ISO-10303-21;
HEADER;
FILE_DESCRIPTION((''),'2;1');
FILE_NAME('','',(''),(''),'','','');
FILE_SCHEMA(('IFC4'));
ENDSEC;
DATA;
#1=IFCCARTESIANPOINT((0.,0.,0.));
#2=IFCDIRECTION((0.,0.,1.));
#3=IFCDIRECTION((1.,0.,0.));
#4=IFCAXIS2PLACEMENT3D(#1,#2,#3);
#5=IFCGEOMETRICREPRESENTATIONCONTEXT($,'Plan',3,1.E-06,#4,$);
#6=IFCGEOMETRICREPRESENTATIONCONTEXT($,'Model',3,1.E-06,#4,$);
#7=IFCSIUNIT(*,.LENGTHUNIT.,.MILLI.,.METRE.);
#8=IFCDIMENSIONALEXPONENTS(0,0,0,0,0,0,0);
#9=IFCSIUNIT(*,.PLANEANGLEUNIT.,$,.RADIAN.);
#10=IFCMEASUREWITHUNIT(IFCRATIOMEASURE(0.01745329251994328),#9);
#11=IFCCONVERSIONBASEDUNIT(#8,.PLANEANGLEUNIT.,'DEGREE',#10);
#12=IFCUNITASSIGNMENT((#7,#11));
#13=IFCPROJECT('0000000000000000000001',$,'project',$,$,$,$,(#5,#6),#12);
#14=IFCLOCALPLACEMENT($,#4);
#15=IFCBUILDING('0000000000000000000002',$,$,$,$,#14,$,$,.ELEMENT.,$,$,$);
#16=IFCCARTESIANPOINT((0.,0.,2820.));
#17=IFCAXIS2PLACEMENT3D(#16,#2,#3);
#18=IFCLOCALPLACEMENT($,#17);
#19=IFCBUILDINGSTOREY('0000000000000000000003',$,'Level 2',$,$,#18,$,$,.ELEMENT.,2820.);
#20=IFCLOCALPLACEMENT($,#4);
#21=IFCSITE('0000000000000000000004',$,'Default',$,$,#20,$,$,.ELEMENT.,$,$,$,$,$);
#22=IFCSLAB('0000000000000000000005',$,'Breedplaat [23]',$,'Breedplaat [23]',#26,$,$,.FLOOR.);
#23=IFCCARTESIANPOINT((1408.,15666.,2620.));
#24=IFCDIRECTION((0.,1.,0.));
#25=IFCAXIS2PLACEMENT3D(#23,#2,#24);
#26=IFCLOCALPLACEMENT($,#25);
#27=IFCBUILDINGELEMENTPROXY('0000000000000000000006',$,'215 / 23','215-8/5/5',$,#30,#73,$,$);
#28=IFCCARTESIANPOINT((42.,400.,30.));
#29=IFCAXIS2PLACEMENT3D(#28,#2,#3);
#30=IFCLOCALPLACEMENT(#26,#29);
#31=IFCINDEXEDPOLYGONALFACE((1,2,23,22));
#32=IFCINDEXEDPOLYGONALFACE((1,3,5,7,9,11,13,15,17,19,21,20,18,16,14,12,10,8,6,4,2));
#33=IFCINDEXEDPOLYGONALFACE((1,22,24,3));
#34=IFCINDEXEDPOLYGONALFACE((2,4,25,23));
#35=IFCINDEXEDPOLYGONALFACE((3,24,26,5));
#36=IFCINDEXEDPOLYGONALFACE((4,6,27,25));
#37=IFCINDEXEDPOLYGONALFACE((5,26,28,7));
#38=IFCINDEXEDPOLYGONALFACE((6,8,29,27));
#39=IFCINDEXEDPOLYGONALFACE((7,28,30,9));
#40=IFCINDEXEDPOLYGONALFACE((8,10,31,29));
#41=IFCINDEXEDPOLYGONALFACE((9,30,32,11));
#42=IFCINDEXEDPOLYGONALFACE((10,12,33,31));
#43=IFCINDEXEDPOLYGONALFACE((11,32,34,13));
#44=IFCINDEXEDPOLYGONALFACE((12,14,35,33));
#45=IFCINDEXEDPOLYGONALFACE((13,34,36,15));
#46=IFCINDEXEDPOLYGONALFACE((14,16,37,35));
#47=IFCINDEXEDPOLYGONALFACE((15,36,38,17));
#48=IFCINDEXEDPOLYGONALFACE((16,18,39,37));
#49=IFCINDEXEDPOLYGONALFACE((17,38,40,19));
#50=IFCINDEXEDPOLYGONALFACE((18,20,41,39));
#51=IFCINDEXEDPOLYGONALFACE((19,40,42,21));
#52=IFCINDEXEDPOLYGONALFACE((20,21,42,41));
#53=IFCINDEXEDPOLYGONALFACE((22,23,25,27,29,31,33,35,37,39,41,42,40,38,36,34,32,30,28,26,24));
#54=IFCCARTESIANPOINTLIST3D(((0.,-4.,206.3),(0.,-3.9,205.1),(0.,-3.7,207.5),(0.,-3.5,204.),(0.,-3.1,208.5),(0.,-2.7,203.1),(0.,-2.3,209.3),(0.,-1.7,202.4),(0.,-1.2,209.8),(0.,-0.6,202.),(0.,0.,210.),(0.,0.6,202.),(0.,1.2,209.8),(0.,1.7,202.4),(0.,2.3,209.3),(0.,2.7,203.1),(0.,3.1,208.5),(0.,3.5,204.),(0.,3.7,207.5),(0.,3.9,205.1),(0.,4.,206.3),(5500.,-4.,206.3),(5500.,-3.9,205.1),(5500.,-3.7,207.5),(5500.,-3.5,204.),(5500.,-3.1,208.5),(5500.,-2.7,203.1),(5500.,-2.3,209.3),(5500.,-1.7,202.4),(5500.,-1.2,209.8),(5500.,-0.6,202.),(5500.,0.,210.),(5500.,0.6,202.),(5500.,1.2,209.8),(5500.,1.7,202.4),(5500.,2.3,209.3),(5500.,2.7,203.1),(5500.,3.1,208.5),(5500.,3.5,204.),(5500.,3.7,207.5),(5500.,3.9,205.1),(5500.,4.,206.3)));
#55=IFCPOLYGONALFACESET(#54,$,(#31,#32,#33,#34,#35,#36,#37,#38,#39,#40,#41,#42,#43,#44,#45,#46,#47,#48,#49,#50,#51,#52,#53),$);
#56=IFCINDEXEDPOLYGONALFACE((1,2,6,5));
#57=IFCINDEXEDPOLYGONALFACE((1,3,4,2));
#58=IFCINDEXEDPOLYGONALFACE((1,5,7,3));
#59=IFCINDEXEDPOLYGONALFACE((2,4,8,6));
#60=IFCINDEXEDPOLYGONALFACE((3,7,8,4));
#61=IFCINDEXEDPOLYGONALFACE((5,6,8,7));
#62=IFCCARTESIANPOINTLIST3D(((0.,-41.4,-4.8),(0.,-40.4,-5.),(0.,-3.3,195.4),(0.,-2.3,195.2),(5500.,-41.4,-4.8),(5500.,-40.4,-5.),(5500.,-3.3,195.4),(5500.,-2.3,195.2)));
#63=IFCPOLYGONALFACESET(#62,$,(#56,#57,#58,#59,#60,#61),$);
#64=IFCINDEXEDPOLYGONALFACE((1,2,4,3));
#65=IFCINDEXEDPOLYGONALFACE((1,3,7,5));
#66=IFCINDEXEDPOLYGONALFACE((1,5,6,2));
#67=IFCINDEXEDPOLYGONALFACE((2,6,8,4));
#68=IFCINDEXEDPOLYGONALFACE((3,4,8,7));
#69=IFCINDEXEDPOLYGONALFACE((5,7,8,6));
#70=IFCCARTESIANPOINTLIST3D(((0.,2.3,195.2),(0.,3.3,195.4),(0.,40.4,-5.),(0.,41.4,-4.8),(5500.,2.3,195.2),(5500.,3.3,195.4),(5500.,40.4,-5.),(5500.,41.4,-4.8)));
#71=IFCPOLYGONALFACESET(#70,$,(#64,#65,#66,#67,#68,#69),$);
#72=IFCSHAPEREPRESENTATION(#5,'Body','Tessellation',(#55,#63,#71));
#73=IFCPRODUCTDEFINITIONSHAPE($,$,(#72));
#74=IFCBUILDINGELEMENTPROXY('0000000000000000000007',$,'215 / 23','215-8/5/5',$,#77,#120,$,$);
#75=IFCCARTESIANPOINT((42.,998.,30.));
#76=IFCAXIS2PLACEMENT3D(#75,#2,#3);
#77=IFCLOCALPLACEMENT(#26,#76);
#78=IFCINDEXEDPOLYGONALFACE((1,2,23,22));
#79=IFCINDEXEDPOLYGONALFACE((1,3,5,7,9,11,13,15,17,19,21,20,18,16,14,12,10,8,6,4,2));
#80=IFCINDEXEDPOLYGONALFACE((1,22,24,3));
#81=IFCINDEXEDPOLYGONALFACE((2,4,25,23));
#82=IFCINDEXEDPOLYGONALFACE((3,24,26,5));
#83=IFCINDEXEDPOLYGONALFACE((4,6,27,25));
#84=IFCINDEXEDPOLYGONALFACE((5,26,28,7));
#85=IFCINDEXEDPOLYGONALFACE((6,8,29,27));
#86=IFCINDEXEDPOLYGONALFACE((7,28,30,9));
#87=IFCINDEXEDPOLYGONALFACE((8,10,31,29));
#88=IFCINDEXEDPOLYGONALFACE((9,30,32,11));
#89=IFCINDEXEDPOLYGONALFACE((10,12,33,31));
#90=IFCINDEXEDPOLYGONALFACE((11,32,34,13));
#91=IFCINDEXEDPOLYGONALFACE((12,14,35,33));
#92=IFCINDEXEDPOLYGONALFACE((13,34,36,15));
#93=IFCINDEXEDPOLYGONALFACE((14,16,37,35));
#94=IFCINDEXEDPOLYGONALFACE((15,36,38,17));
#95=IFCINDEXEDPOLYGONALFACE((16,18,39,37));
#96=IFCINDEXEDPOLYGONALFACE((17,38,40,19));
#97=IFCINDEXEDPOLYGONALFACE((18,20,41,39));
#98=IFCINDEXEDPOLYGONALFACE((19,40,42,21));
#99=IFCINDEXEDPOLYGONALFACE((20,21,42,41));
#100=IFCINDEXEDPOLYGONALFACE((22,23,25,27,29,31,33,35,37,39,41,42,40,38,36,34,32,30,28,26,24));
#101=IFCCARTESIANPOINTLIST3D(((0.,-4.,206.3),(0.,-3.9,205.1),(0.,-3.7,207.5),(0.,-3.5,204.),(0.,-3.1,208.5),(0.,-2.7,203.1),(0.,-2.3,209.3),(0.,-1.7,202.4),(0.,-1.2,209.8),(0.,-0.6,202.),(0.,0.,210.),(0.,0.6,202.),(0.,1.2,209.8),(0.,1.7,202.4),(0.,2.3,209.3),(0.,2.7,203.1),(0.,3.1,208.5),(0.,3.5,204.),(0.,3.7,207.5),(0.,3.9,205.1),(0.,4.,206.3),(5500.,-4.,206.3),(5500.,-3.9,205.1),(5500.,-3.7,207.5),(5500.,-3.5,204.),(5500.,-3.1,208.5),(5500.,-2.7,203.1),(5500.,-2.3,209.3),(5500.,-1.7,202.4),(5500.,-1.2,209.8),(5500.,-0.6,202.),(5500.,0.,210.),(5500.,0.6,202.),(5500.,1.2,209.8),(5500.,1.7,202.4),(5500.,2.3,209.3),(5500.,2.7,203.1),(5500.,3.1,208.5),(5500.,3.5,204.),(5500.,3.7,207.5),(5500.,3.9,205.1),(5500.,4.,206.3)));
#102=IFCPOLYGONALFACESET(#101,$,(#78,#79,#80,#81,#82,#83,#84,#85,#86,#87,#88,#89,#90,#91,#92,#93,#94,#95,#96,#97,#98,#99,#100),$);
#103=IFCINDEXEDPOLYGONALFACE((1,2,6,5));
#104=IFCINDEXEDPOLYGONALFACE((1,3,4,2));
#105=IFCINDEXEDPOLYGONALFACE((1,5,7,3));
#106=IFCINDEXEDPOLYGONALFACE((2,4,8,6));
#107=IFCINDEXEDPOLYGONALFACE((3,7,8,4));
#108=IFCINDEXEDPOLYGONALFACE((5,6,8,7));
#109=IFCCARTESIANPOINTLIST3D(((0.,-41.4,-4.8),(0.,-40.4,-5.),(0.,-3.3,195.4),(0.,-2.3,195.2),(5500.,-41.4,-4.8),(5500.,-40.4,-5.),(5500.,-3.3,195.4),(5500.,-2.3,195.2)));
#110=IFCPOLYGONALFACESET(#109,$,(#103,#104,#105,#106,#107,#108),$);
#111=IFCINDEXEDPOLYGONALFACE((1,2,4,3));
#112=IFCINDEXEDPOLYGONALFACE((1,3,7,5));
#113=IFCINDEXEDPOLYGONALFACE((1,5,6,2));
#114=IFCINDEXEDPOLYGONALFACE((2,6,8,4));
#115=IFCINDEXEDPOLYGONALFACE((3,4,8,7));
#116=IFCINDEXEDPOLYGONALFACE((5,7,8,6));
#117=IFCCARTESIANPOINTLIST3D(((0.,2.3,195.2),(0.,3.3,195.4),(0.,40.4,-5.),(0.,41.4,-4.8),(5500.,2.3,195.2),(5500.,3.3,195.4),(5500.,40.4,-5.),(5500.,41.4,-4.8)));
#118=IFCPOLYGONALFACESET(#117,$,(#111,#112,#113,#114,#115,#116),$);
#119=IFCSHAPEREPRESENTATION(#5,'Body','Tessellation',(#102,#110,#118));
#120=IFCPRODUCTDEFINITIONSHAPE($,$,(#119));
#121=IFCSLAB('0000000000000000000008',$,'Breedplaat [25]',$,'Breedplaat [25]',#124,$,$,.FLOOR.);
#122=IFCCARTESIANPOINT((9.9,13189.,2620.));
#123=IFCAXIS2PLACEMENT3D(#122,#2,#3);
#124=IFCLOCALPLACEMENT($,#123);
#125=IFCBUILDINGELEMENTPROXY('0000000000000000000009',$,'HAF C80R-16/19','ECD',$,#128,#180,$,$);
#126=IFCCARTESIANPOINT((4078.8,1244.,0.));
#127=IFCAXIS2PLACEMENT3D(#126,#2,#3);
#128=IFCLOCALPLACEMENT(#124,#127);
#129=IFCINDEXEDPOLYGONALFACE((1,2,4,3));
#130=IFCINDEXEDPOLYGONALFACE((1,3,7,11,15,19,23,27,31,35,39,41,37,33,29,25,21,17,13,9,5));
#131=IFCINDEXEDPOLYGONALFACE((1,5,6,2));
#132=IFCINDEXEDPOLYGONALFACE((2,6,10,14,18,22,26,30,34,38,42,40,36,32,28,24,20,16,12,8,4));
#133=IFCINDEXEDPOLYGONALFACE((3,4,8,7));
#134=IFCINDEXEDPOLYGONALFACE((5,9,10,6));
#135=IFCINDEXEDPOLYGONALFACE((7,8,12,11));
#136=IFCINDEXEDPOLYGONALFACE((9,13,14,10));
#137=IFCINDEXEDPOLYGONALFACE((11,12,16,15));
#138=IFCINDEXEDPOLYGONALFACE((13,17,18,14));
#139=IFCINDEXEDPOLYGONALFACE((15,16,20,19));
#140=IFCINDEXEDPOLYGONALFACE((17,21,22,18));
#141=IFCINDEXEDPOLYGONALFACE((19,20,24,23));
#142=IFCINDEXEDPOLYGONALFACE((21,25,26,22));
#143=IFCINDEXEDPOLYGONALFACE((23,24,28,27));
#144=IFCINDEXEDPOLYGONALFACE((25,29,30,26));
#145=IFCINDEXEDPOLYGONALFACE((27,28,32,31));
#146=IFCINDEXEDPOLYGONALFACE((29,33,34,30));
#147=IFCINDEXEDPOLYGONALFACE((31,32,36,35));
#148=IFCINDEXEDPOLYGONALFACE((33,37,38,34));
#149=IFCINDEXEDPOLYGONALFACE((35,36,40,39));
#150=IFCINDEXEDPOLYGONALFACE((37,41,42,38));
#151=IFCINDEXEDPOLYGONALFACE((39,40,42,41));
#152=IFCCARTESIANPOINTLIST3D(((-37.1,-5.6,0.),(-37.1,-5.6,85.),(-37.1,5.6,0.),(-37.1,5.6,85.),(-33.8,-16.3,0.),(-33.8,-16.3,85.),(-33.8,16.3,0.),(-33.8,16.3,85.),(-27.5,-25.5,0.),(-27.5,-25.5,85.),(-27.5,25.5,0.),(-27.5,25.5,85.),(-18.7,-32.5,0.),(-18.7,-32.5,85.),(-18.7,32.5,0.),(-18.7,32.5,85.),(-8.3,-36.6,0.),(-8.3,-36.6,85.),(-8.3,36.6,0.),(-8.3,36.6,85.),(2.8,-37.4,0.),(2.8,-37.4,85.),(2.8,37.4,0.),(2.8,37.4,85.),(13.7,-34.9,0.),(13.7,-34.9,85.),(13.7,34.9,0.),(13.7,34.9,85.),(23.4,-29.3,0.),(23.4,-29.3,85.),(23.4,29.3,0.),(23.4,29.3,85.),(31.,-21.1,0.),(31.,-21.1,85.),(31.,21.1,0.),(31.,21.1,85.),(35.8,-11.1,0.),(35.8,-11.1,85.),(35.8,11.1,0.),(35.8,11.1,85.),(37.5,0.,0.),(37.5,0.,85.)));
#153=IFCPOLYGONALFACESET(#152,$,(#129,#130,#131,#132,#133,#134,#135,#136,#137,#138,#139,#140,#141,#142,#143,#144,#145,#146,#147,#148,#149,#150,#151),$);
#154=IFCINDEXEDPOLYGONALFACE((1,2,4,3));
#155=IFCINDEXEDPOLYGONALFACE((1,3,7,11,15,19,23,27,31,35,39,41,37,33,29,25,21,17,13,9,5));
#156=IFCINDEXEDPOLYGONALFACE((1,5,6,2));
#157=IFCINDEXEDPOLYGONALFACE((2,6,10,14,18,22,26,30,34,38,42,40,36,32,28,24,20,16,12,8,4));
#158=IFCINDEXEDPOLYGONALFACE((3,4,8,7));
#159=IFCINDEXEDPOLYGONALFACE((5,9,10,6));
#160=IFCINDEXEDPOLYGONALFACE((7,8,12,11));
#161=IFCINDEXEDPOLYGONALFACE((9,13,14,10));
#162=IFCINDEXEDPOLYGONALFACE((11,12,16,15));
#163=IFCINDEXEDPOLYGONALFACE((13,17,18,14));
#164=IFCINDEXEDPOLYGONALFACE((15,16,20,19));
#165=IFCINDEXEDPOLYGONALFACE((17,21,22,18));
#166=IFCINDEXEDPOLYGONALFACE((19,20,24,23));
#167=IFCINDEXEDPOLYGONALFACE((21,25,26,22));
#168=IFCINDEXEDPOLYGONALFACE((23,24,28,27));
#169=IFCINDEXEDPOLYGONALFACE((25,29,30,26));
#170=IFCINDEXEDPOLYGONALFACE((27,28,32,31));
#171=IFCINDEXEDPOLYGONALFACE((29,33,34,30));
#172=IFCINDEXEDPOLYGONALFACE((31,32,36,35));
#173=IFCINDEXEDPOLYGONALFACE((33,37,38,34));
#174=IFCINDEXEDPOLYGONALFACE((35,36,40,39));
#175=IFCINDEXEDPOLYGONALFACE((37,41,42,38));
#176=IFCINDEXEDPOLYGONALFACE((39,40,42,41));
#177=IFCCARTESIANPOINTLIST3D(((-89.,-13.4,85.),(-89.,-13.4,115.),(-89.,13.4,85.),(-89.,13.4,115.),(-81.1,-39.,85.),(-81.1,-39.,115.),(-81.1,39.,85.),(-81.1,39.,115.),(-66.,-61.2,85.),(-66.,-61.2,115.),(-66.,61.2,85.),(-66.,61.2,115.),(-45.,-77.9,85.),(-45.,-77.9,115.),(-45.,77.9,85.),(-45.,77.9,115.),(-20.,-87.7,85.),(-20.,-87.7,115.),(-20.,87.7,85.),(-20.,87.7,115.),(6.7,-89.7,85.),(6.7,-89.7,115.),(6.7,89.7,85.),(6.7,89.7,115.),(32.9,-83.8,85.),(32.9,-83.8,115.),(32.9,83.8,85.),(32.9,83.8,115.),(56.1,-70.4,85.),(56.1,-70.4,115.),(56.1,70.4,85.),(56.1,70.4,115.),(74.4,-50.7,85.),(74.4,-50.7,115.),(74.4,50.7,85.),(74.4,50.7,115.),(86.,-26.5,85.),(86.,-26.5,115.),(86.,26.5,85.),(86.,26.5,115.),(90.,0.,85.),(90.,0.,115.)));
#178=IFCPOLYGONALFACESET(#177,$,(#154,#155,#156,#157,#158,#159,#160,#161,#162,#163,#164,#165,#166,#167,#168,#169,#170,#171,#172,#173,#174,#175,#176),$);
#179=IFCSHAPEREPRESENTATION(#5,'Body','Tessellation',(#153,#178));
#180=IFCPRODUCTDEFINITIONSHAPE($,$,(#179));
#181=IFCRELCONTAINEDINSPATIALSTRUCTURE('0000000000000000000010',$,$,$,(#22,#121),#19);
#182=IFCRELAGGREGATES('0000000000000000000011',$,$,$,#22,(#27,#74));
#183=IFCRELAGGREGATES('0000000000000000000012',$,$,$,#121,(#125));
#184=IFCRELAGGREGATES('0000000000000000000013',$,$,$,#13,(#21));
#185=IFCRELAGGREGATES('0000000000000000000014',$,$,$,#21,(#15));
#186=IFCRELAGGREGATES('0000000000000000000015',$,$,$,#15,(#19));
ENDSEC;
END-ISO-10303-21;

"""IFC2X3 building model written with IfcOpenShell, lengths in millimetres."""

from ifc_helpers import new_model, entity, si_unit, converted_unit, frame, origin_with_axes, origin_2d_with_axis, place, context, project, spatial, rectangle, circle, extrude, element, aggregate, save


model = new_model("IFC2X3")

# Units and contexts
plan_context = context("Plan", 3, precision=1e-06, world=origin_with_axes())
model_context = context("Model", 3, precision=1e-06, world=origin_with_axes())
ifc_project = project(units=[si_unit("LENGTHUNIT", "METRE", prefix="MILLI"), converted_unit("PLANEANGLEUNIT", "DEGREE", entity("IfcRatioMeasure", 0.01745329251994328), si_unit("PLANEANGLEUNIT", "RADIAN"), dimensions=[0, 0, 0, 0, 0, 0, 0])], contexts=[plan_context, model_context])

# Site, building, storey
site_placement = place(None, origin_with_axes())
site = spatial("IfcSite", under=ifc_project, at=site_placement, Name="Default", CompositionType="ELEMENT")
building_placement = place(None, origin_with_axes())
building = spatial("IfcBuilding", under=site, at=building_placement, CompositionType="ELEMENT")
storey_placement = place(None, frame((0.0, 0.0, 2820.0), z_axis=(0.0, 0.0, 1.0), x_axis=(1.0, 0.0, 0.0)))
storey = spatial("IfcBuildingStorey", under=building, at=storey_placement, Name="Level 2", CompositionType="ELEMENT", Elevation=2820.0)

# Slab, building element proxies
slab_1_placement = place(None, frame((1408.0, 15666.0, 2620.0), z_axis=(0.0, 0.0, 1.0), x_axis=(0.0, 1.0, 0.0)))
slab_1 = element("IfcSlab", 1, at=slab_1_placement, inside=storey, Name="Breedplaat [23]", ObjectType="Breedplaat [23]", PredefinedType="FLOOR")
proxy_1_placement = place(slab_1_placement, frame((42.0, 400.0, 30.0), z_axis=(0.0, 0.0, 1.0), x_axis=(1.0, 0.0, 0.0)))
proxy_1 = element("IfcBuildingElementProxy", 2, at=proxy_1_placement, Name="215 / 23", Description="215-8/5/5", context=plan_context, shape_type="SweptSolid", body=[
    extrude(circle(Radius=4.0, at=origin_2d_with_axis()), frame((0.0, 0.0, 206.0), z_axis=(1.0, 0.0, 0.0), x_axis=(0.0, 0.0, 1.0)), (0.0, 0.0, 1.0), 5500.0),
    extrude(rectangle(XDim=203.8, YDim=1.0, at=origin_2d_with_axis()), frame((0.0, -21.9, 95.2), z_axis=(1.0, 0.0, 0.0), x_axis=(0.0, 0.187112, 0.982339)), (0.0, 0.0, 1.0), 5500.0),
    extrude(rectangle(XDim=203.8, YDim=1.0, at=origin_2d_with_axis()), frame((0.0, 21.9, 95.2), z_axis=(1.0, 0.0, 0.0), x_axis=(0.0, -0.187112, 0.982339)), (0.0, 0.0, 1.0), 5500.0),
])
proxy_2_placement = place(slab_1_placement, frame((42.0, 998.0, 30.0), z_axis=(0.0, 0.0, 1.0), x_axis=(1.0, 0.0, 0.0)))
proxy_2 = element("IfcBuildingElementProxy", 3, at=proxy_2_placement, Name="215 / 23", Description="215-8/5/5", context=plan_context, shape_type="SweptSolid", body=[
    extrude(circle(Radius=4.0, at=origin_2d_with_axis()), frame((0.0, 0.0, 206.0), z_axis=(1.0, 0.0, 0.0), x_axis=(0.0, 0.0, 1.0)), (0.0, 0.0, 1.0), 5500.0),
    extrude(rectangle(XDim=203.8, YDim=1.0, at=origin_2d_with_axis()), frame((0.0, -21.9, 95.2), z_axis=(1.0, 0.0, 0.0), x_axis=(0.0, 0.187112, 0.982339)), (0.0, 0.0, 1.0), 5500.0),
    extrude(rectangle(XDim=203.8, YDim=1.0, at=origin_2d_with_axis()), frame((0.0, 21.9, 95.2), z_axis=(1.0, 0.0, 0.0), x_axis=(0.0, -0.187112, 0.982339)), (0.0, 0.0, 1.0), 5500.0),
])
aggregate(slab_1, [proxy_1, proxy_2])

# Slab, building element proxy
slab_2_placement = place(None, frame((9.9, 13189.0, 2620.0), z_axis=(0.0, 0.0, 1.0), x_axis=(1.0, 0.0, 0.0)))
slab_2 = element("IfcSlab", 4, at=slab_2_placement, inside=storey, Name="Breedplaat [25]", ObjectType="Breedplaat [25]", PredefinedType="FLOOR")
proxy_3_placement = place(slab_2_placement, frame((4078.8, 1244.0, 0.0), z_axis=(0.0, 0.0, 1.0), x_axis=(1.0, 0.0, 0.0)))
proxy_3 = element("IfcBuildingElementProxy", 5, at=proxy_3_placement, Name="HAF C80R-16/19", Description="ECD", context=plan_context, shape_type="SweptSolid", body=[
    extrude(circle(Radius=37.5, at=origin_2d_with_axis()), origin_with_axes(), (0.0, 0.0, 1.0), 85.0),
    extrude(circle(Radius=90.0, at=origin_2d_with_axis()), frame((0.0, 0.0, 85.0), z_axis=(0.0, 0.0, 1.0), x_axis=(1.0, 0.0, 0.0)), (0.0, 0.0, 1.0), 30.0),
])
aggregate(slab_2, [proxy_3])

save(model, "model.ifc")
